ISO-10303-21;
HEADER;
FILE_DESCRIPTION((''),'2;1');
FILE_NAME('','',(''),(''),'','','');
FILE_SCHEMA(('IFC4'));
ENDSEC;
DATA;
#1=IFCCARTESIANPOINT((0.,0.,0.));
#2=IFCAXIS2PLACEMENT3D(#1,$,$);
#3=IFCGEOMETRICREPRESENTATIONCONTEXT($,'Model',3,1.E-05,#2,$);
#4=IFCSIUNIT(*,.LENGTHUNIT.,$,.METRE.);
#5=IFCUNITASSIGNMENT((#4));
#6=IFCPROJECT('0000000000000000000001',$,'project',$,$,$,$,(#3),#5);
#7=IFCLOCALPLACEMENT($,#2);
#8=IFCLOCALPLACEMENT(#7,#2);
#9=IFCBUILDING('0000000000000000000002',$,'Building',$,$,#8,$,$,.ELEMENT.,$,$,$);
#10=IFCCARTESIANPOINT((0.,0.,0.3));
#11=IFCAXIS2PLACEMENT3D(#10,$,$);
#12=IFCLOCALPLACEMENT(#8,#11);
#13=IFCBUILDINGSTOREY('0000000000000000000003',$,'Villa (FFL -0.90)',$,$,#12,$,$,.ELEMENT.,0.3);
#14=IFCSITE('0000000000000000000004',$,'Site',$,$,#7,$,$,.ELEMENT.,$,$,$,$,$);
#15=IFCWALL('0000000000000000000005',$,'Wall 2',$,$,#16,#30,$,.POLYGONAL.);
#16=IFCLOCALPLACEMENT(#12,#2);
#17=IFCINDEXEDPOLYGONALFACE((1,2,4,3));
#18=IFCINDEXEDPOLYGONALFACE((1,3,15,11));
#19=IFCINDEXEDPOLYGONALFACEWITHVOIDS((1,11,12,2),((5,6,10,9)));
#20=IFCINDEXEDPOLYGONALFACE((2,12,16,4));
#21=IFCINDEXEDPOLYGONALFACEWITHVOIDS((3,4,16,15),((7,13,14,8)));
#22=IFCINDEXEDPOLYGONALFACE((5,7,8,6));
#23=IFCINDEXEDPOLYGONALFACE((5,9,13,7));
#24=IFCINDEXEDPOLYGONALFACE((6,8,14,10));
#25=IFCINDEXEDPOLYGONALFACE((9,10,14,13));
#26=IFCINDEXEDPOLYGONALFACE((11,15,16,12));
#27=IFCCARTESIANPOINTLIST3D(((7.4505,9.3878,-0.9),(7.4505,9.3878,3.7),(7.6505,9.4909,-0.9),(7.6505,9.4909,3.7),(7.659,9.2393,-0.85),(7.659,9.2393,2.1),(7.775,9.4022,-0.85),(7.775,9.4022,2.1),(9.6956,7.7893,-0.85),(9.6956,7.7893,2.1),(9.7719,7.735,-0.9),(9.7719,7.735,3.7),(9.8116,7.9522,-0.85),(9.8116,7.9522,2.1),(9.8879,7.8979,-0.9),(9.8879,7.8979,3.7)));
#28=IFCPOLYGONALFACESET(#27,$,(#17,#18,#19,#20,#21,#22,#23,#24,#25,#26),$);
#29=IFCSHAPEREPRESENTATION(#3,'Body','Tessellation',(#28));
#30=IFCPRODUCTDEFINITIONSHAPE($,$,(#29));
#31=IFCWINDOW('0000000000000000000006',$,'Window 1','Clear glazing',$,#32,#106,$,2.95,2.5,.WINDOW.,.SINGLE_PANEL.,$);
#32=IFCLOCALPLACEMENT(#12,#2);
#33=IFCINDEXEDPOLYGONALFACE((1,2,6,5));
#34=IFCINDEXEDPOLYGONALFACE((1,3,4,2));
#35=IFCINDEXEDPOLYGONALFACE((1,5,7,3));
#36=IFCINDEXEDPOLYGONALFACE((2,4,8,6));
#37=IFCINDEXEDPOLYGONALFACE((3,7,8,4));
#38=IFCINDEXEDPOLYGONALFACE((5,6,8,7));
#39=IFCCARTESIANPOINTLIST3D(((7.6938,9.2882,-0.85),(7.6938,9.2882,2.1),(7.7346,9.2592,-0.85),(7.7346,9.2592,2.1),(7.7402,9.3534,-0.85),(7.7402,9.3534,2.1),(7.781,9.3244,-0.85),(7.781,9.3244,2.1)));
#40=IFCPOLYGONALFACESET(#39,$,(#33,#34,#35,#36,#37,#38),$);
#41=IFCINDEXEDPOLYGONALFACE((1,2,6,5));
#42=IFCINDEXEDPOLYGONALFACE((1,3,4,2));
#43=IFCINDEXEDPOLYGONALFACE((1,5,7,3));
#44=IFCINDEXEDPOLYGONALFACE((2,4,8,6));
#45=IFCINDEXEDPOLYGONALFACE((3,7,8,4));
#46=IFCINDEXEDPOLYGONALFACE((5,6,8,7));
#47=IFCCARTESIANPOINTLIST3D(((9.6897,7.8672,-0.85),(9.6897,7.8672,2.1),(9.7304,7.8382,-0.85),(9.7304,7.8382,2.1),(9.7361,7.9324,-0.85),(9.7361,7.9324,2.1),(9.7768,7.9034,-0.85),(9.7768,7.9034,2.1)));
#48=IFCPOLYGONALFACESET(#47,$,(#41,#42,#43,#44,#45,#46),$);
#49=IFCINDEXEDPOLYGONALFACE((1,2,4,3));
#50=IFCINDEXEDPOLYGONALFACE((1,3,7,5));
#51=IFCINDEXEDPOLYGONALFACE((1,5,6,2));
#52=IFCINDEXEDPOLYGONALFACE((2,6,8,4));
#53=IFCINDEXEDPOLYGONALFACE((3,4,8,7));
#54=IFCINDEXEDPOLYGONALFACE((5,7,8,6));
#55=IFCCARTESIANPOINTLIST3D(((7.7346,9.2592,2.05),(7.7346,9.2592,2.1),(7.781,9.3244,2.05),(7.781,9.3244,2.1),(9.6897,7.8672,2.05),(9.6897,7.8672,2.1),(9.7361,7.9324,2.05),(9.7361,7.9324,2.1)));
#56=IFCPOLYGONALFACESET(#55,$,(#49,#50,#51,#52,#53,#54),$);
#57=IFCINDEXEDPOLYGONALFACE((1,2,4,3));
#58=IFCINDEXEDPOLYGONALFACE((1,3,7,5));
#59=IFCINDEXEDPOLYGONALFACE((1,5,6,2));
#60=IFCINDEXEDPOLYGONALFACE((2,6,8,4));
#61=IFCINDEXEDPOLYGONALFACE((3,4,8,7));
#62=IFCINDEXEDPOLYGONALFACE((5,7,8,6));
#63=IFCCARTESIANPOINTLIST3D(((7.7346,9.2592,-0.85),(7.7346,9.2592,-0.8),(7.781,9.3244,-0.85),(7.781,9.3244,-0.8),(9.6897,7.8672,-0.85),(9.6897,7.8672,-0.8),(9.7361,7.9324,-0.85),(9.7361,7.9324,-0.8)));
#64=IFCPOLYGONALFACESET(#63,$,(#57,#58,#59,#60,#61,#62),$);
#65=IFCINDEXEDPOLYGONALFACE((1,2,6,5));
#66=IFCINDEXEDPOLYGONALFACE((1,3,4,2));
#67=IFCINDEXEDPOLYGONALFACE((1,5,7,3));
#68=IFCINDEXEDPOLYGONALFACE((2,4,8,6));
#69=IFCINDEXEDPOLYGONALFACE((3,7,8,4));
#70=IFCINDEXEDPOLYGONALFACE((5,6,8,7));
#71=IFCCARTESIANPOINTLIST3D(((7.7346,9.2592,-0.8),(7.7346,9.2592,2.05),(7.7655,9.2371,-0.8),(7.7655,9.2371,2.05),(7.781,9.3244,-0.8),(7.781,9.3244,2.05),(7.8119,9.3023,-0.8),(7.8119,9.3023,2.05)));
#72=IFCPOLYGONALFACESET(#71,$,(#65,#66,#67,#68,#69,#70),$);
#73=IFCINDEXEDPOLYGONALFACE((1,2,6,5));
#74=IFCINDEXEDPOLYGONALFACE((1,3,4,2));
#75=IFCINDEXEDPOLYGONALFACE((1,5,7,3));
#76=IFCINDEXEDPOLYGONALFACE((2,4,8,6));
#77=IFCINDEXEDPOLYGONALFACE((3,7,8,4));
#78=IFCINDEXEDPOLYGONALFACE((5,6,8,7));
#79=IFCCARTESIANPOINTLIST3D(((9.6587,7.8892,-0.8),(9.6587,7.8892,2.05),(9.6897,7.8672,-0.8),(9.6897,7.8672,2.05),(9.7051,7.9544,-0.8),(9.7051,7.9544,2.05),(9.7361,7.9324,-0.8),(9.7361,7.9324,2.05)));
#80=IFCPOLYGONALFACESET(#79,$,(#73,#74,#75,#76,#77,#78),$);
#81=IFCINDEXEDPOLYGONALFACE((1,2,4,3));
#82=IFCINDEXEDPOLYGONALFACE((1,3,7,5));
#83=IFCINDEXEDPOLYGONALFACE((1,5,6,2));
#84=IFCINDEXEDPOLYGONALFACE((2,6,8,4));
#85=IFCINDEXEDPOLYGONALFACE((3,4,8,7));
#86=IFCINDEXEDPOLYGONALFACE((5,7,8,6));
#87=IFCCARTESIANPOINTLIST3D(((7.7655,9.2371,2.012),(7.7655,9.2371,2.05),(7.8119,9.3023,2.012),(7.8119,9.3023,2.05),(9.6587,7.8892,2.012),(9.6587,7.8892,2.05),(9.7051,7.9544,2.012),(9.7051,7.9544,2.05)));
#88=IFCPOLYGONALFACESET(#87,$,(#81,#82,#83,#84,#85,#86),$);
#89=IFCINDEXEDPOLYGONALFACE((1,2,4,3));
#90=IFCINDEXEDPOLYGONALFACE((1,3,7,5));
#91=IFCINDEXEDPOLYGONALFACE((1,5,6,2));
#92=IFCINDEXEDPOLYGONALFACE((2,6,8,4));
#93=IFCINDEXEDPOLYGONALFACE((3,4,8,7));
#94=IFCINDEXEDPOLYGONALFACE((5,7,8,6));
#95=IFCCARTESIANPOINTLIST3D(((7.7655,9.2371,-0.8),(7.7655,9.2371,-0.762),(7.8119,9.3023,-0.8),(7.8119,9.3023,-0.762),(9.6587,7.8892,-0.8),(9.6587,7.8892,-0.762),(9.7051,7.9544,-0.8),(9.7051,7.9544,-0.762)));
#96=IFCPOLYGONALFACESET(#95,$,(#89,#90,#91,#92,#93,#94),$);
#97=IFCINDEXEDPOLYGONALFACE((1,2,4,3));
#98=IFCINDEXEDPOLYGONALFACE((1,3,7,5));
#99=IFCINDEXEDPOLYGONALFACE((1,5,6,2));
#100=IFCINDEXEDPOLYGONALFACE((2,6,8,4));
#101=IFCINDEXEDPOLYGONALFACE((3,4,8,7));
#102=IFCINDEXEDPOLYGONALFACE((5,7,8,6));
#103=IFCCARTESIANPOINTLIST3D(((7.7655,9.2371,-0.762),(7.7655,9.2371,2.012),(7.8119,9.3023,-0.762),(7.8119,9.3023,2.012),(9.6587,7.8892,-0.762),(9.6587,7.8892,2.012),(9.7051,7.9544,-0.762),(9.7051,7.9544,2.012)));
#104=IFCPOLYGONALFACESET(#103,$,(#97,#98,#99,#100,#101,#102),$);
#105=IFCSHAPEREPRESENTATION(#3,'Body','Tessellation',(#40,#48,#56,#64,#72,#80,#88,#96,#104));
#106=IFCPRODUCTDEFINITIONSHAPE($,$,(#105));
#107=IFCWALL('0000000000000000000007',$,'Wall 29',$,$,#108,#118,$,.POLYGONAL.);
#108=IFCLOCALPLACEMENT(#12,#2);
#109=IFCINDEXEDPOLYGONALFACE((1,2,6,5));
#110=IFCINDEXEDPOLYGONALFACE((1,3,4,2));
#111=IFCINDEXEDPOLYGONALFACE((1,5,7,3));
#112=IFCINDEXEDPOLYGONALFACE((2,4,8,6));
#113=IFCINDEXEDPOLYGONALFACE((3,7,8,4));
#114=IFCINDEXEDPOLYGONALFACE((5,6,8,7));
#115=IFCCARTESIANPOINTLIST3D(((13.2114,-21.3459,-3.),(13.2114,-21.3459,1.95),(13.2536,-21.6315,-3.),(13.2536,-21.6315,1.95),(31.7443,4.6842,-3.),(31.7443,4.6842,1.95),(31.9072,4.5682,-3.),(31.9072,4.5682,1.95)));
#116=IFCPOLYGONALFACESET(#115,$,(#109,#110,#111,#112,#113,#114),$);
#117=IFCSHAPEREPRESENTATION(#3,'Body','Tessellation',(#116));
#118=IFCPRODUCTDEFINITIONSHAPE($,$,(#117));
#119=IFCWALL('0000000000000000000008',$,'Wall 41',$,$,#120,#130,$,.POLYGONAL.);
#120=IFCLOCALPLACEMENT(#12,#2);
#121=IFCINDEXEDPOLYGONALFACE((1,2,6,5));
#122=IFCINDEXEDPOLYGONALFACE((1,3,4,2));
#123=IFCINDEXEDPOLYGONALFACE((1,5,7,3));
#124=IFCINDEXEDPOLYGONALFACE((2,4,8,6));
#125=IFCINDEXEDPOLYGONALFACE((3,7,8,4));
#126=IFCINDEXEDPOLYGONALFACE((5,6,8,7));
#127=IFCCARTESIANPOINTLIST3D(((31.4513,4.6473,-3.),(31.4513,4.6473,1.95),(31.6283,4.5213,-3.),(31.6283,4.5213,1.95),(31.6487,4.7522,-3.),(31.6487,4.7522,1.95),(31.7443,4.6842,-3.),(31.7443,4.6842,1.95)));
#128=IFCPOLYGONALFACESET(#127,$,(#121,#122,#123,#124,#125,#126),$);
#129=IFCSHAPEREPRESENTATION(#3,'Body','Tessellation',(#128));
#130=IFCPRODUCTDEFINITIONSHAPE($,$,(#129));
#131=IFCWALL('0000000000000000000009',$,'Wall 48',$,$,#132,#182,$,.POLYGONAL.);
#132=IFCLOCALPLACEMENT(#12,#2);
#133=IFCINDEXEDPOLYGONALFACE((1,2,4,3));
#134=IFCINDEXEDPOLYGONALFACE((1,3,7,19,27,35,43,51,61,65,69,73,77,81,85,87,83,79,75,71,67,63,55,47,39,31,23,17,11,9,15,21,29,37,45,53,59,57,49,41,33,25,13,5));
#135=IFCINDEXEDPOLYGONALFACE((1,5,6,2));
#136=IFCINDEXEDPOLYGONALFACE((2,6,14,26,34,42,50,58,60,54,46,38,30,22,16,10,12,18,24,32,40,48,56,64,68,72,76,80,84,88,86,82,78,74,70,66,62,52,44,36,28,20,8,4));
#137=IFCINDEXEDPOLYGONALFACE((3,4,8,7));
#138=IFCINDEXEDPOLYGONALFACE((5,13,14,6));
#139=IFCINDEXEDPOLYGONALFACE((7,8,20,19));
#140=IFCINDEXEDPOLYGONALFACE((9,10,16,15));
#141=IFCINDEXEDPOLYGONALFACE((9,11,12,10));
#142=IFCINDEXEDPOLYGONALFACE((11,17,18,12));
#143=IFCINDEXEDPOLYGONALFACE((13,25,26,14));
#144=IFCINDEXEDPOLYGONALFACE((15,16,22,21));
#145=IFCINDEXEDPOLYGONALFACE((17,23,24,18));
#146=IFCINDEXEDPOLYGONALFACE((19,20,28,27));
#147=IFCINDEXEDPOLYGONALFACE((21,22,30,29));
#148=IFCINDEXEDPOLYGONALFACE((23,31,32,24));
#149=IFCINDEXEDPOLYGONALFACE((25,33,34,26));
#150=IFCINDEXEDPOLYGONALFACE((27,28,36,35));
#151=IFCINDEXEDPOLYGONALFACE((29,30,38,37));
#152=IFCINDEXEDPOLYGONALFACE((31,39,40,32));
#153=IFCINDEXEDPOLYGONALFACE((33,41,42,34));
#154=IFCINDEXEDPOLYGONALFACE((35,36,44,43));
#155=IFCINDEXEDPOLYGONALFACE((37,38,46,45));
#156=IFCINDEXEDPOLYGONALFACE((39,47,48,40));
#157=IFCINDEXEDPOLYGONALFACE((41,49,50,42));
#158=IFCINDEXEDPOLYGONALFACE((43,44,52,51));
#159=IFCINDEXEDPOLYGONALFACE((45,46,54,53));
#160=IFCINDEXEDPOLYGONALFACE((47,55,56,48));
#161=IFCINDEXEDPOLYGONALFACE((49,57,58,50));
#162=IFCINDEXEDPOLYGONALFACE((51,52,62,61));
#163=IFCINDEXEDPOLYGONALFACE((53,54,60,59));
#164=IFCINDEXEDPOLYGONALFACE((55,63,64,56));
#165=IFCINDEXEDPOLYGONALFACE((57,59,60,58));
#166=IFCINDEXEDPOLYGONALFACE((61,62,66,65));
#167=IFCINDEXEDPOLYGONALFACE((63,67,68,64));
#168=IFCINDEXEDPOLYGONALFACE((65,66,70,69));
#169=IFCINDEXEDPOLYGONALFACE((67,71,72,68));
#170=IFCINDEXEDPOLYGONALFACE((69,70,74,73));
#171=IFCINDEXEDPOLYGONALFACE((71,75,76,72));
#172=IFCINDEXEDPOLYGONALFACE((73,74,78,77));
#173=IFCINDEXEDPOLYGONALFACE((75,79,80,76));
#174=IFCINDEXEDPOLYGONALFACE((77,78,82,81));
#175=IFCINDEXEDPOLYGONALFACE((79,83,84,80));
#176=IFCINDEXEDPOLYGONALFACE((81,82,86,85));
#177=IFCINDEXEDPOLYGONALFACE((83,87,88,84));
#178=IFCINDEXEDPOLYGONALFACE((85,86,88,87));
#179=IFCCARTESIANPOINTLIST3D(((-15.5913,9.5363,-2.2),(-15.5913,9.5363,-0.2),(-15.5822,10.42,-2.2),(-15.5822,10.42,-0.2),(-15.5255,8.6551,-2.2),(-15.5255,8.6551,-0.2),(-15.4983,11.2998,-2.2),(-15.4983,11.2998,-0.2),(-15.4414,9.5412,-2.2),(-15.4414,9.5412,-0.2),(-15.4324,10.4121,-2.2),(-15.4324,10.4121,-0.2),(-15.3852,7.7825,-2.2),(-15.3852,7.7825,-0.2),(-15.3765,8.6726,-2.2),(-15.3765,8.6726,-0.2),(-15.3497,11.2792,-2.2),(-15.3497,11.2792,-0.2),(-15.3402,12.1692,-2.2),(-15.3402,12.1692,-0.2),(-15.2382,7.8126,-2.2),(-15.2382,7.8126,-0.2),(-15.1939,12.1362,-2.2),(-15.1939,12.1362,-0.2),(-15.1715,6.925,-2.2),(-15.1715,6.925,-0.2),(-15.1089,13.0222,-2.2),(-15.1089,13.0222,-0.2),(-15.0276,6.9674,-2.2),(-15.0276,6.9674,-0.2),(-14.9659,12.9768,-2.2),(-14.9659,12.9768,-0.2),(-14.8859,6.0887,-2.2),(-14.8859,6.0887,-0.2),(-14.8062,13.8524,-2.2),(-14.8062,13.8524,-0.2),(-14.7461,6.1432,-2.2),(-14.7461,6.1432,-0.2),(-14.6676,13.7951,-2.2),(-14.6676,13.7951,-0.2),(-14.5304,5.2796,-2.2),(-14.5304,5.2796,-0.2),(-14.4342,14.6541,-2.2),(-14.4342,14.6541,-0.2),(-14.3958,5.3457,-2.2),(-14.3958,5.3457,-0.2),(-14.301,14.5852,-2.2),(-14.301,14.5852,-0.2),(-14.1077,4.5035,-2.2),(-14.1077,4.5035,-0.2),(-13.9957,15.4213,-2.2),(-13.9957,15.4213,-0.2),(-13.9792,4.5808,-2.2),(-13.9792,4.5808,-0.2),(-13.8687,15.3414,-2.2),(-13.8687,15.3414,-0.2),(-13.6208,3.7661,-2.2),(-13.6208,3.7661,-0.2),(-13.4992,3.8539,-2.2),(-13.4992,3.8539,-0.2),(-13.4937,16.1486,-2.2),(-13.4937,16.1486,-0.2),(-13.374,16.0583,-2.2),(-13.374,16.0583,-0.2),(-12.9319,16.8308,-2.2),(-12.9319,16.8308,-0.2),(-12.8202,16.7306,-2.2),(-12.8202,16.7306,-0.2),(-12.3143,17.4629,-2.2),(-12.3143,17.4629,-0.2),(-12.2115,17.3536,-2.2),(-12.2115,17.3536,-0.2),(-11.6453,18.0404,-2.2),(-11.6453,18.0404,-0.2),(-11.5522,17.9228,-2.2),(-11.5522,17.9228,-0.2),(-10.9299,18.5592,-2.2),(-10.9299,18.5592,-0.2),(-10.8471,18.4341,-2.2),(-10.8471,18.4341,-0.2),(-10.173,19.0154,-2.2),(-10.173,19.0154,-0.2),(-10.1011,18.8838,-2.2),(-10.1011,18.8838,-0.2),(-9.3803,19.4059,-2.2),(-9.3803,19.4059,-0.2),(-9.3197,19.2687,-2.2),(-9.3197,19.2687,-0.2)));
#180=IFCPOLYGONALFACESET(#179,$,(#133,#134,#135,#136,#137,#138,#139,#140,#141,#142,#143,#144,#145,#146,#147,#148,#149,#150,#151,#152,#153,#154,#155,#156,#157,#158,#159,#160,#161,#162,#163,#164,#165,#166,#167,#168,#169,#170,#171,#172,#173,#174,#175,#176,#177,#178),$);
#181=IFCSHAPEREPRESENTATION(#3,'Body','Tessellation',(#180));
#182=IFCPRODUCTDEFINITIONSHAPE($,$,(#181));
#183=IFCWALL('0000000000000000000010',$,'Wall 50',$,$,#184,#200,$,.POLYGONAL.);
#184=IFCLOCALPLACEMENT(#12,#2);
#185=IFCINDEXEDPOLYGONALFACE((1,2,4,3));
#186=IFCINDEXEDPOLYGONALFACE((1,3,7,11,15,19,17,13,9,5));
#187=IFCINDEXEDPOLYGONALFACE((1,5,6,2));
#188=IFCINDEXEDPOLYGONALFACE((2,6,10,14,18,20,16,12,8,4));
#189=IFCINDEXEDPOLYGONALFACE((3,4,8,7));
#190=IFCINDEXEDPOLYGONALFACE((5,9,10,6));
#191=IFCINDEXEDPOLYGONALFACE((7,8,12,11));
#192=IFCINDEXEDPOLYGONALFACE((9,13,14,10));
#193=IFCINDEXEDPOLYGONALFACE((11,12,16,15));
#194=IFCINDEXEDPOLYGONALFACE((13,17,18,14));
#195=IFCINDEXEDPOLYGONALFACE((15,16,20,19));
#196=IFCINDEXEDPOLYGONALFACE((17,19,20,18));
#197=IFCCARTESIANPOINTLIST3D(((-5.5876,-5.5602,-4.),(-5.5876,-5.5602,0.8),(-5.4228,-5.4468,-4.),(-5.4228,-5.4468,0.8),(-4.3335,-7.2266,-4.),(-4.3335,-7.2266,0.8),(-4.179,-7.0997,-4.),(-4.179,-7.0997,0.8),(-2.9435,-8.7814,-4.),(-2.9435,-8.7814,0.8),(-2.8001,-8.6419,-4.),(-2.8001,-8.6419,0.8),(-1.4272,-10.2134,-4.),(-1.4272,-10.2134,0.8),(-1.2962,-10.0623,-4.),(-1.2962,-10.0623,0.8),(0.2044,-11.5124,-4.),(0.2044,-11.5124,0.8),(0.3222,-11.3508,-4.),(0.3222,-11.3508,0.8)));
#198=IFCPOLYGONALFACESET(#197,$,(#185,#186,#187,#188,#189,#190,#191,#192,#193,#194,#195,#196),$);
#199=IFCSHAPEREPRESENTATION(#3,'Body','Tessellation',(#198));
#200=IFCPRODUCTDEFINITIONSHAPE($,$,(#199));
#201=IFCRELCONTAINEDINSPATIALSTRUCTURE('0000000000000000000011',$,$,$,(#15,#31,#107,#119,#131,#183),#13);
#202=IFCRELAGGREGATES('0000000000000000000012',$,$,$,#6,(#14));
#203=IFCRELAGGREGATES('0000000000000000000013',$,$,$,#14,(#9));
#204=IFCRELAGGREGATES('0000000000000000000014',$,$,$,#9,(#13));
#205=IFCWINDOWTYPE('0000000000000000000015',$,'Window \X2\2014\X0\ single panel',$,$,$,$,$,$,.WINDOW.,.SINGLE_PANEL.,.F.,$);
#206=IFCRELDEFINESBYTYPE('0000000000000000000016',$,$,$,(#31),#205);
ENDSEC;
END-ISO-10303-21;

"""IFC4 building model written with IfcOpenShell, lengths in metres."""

from ifc_helpers import new_model, si_unit, frame, frame_2d, origin, place, context, project, spatial, polyline, rectangle, outline, extrude, type_object, element, fill, save


model = new_model("IFC4")

# Units and contexts
model_context = context("Model", 3, precision=1e-05, world=origin())
ifc_project = project(units=[si_unit("LENGTHUNIT", "METRE")], contexts=[model_context])

# Site, building, storey
site_placement = place(None, origin())
site = spatial("IfcSite", under=ifc_project, at=site_placement, Name="Site", CompositionType="ELEMENT")
building_placement = place(site_placement, origin())
building = spatial("IfcBuilding", under=site, at=building_placement, Name="Building", CompositionType="ELEMENT")
storey_placement = place(building_placement, frame((0.0, 0.0, 0.3)))
storey = spatial("IfcBuildingStorey", under=building, at=storey_placement, Name="Villa (FFL -0.90)", CompositionType="ELEMENT", Elevation=0.3)

# Wall, opening, window
wall_1_placement = place(storey_placement, frame((0.0, 0.0, -0.9), z_axis=(0.0, 0.0, 1.0), x_axis=(1.0, 0.0, 0.0)))
wall_1 = element("IfcWall", 1, at=wall_1_placement, inside=storey, Name="Wall 2", PredefinedType="POLYGONAL", context=model_context, shape_type="SweptSolid", body=[
    extrude(outline(polyline([(7.6505, 9.4909), (7.4505, 9.3878), (9.7719, 7.735), (9.8879, 7.8979), (7.6505, 9.4909)])), origin(), (0.0, 0.0, 1.0), 4.6),
])
opening_placement = place(storey_placement, frame((7.717, 9.3208, -0.85), z_axis=(0.0, 0.0, 1.0), x_axis=(0.814622, -0.579992, 0.0)))
opening = element("IfcOpeningElement", 2, at=opening_placement, cuts=wall_1, PredefinedType="OPENING", context=model_context, shape_type="SweptSolid", body=[
    extrude(rectangle(XDim=2.5, YDim=0.26, at=frame_2d((1.25, 0.0))), origin(), (0.0, 0.0, 1.0), 2.95),
])
window_type = type_object("IfcWindowType", Name="Window — single panel", ParameterTakesPrecedence=False, PartitioningType="SINGLE_PANEL", PredefinedType="WINDOW")
window_placement = place(storey_placement, frame((7.717, 9.3208, -0.85), z_axis=(0.0, 0.0, 1.0), x_axis=(0.814622, -0.579992, 0.0)))
window = element("IfcWindow", 3, at=window_placement, inside=storey, type_object=window_type, Name="Window 1", Description="Clear glazing", OverallHeight=2.95, OverallWidth=2.5, PartitioningType="SINGLE_PANEL", PredefinedType="WINDOW", context=model_context, shape_type="SweptSolid", body=[
    extrude(rectangle(XDim=0.05, YDim=0.08, at=frame_2d((0.025, 0.0))), origin(), (0.0, 0.0, 1.0), 2.95),
    extrude(rectangle(XDim=0.05, YDim=0.08, at=frame_2d((2.475, 0.0))), origin(), (0.0, 0.0, 1.0), 2.95),
    extrude(rectangle(XDim=2.4, YDim=0.08, at=frame_2d((1.25, 0.0))), frame((0.0, 0.0, 2.9)), (0.0, 0.0, 1.0), 0.05),
    extrude(rectangle(XDim=2.4, YDim=0.08, at=frame_2d((1.25, 0.0))), origin(), (0.0, 0.0, 1.0), 0.05),
    extrude(rectangle(XDim=0.038, YDim=0.08, at=frame_2d((0.069, 0.0))), frame((0.0, 0.0, 0.05)), (0.0, 0.0, 1.0), 2.85),
    extrude(rectangle(XDim=0.038, YDim=0.08, at=frame_2d((2.431, 0.0))), frame((0.0, 0.0, 0.05)), (0.0, 0.0, 1.0), 2.85),
    extrude(rectangle(XDim=2.324, YDim=0.08, at=frame_2d((1.25, 0.0))), frame((0.0, 0.0, 2.862)), (0.0, 0.0, 1.0), 0.038),
    extrude(rectangle(XDim=2.324, YDim=0.08, at=frame_2d((1.25, 0.0))), frame((0.0, 0.0, 0.05)), (0.0, 0.0, 1.0), 0.038),
    extrude(rectangle(XDim=2.324, YDim=0.08, at=frame_2d((1.25, 0.0))), frame((0.0, 0.0, 0.088)), (0.0, 0.0, 1.0), 2.774),
])
fill(opening, window)

# Walls
wall_2_placement = place(storey_placement, frame((0.0, 0.0, -3.0), z_axis=(0.0, 0.0, 1.0), x_axis=(1.0, 0.0, 0.0)))
element("IfcWall", 4, at=wall_2_placement, inside=storey, Name="Wall 29", PredefinedType="POLYGONAL", context=model_context, shape_type="SweptSolid", body=[
    extrude(outline(polyline([(13.2114, -21.3459), (13.2536, -21.6315), (31.9072, 4.5682), (31.7443, 4.6842), (13.2114, -21.3459)])), origin(), (0.0, 0.0, 1.0), 4.95),
])
wall_3_placement = place(storey_placement, frame((0.0, 0.0, -3.0), z_axis=(0.0, 0.0, 1.0), x_axis=(1.0, 0.0, 0.0)))
element("IfcWall", 5, at=wall_3_placement, inside=storey, Name="Wall 41", PredefinedType="POLYGONAL", context=model_context, shape_type="SweptSolid", body=[
    extrude(outline(polyline([(31.6283, 4.5213), (31.7443, 4.6842), (31.6487, 4.7522), (31.4513, 4.6473), (31.6283, 4.5213)])), origin(), (0.0, 0.0, 1.0), 4.95),
])
wall_4_placement = place(storey_placement, frame((0.0, 0.0, -2.2), z_axis=(0.0, 0.0, 1.0), x_axis=(1.0, 0.0, 0.0)))
element("IfcWall", 6, at=wall_4_placement, inside=storey, Name="Wall 48", PredefinedType="POLYGONAL", context=model_context, shape_type="SweptSolid", body=[
    extrude(outline(polyline([(-13.6208, 3.7661), (-14.1077, 4.5035), (-14.5304, 5.2796), (-14.8859, 6.0887), (-15.1715, 6.925), (-15.3852, 7.7825), (-15.5255, 8.6551), (-15.5913, 9.5363), (-15.5822, 10.42), (-15.4983, 11.2998), (-15.3402, 12.1692), (-15.1089, 13.0222), (-14.8062, 13.8524), (-14.4342, 14.6541), (-13.9957, 15.4213), (-13.4937, 16.1486), (-12.9319, 16.8308), (-12.3143, 17.4629), (-11.6453, 18.0404), (-10.9299, 18.5592), (-10.173, 19.0154), (-9.3803, 19.4059), (-9.3197, 19.2687), (-10.1011, 18.8838), (-10.8471, 18.4341), (-11.5522, 17.9228), (-12.2115, 17.3536), (-12.8202, 16.7306), (-13.374, 16.0583), (-13.8687, 15.3414), (-14.301, 14.5852), (-14.6676, 13.7951), (-14.9659, 12.9768), (-15.1939, 12.1362), (-15.3497, 11.2792), (-15.4324, 10.4121), (-15.4414, 9.5412), (-15.3765, 8.6726), (-15.2382, 7.8126), (-15.0276, 6.9674), (-14.7461, 6.1432), (-14.3958, 5.3457), (-13.9792, 4.5808), (-13.4992, 3.8539), (-13.6208, 3.7661)])), origin(), (0.0, 0.0, 1.0), 2.0),
])
wall_5_placement = place(storey_placement, frame((0.0, 0.0, -4.0), z_axis=(0.0, 0.0, 1.0), x_axis=(1.0, 0.0, 0.0)))
element("IfcWall", 7, at=wall_5_placement, inside=storey, Name="Wall 50", PredefinedType="POLYGONAL", context=model_context, shape_type="SweptSolid", body=[
    extrude(outline(polyline([(-5.5876, -5.5602), (-4.3335, -7.2266), (-2.9435, -8.7814), (-1.4272, -10.2134), (0.2044, -11.5124), (0.3222, -11.3508), (-1.2962, -10.0623), (-2.8001, -8.6419), (-4.179, -7.0997), (-5.4228, -5.4468), (-5.5876, -5.5602)])), origin(), (0.0, 0.0, 1.0), 4.8),
])

save(model, "model.ifc")
